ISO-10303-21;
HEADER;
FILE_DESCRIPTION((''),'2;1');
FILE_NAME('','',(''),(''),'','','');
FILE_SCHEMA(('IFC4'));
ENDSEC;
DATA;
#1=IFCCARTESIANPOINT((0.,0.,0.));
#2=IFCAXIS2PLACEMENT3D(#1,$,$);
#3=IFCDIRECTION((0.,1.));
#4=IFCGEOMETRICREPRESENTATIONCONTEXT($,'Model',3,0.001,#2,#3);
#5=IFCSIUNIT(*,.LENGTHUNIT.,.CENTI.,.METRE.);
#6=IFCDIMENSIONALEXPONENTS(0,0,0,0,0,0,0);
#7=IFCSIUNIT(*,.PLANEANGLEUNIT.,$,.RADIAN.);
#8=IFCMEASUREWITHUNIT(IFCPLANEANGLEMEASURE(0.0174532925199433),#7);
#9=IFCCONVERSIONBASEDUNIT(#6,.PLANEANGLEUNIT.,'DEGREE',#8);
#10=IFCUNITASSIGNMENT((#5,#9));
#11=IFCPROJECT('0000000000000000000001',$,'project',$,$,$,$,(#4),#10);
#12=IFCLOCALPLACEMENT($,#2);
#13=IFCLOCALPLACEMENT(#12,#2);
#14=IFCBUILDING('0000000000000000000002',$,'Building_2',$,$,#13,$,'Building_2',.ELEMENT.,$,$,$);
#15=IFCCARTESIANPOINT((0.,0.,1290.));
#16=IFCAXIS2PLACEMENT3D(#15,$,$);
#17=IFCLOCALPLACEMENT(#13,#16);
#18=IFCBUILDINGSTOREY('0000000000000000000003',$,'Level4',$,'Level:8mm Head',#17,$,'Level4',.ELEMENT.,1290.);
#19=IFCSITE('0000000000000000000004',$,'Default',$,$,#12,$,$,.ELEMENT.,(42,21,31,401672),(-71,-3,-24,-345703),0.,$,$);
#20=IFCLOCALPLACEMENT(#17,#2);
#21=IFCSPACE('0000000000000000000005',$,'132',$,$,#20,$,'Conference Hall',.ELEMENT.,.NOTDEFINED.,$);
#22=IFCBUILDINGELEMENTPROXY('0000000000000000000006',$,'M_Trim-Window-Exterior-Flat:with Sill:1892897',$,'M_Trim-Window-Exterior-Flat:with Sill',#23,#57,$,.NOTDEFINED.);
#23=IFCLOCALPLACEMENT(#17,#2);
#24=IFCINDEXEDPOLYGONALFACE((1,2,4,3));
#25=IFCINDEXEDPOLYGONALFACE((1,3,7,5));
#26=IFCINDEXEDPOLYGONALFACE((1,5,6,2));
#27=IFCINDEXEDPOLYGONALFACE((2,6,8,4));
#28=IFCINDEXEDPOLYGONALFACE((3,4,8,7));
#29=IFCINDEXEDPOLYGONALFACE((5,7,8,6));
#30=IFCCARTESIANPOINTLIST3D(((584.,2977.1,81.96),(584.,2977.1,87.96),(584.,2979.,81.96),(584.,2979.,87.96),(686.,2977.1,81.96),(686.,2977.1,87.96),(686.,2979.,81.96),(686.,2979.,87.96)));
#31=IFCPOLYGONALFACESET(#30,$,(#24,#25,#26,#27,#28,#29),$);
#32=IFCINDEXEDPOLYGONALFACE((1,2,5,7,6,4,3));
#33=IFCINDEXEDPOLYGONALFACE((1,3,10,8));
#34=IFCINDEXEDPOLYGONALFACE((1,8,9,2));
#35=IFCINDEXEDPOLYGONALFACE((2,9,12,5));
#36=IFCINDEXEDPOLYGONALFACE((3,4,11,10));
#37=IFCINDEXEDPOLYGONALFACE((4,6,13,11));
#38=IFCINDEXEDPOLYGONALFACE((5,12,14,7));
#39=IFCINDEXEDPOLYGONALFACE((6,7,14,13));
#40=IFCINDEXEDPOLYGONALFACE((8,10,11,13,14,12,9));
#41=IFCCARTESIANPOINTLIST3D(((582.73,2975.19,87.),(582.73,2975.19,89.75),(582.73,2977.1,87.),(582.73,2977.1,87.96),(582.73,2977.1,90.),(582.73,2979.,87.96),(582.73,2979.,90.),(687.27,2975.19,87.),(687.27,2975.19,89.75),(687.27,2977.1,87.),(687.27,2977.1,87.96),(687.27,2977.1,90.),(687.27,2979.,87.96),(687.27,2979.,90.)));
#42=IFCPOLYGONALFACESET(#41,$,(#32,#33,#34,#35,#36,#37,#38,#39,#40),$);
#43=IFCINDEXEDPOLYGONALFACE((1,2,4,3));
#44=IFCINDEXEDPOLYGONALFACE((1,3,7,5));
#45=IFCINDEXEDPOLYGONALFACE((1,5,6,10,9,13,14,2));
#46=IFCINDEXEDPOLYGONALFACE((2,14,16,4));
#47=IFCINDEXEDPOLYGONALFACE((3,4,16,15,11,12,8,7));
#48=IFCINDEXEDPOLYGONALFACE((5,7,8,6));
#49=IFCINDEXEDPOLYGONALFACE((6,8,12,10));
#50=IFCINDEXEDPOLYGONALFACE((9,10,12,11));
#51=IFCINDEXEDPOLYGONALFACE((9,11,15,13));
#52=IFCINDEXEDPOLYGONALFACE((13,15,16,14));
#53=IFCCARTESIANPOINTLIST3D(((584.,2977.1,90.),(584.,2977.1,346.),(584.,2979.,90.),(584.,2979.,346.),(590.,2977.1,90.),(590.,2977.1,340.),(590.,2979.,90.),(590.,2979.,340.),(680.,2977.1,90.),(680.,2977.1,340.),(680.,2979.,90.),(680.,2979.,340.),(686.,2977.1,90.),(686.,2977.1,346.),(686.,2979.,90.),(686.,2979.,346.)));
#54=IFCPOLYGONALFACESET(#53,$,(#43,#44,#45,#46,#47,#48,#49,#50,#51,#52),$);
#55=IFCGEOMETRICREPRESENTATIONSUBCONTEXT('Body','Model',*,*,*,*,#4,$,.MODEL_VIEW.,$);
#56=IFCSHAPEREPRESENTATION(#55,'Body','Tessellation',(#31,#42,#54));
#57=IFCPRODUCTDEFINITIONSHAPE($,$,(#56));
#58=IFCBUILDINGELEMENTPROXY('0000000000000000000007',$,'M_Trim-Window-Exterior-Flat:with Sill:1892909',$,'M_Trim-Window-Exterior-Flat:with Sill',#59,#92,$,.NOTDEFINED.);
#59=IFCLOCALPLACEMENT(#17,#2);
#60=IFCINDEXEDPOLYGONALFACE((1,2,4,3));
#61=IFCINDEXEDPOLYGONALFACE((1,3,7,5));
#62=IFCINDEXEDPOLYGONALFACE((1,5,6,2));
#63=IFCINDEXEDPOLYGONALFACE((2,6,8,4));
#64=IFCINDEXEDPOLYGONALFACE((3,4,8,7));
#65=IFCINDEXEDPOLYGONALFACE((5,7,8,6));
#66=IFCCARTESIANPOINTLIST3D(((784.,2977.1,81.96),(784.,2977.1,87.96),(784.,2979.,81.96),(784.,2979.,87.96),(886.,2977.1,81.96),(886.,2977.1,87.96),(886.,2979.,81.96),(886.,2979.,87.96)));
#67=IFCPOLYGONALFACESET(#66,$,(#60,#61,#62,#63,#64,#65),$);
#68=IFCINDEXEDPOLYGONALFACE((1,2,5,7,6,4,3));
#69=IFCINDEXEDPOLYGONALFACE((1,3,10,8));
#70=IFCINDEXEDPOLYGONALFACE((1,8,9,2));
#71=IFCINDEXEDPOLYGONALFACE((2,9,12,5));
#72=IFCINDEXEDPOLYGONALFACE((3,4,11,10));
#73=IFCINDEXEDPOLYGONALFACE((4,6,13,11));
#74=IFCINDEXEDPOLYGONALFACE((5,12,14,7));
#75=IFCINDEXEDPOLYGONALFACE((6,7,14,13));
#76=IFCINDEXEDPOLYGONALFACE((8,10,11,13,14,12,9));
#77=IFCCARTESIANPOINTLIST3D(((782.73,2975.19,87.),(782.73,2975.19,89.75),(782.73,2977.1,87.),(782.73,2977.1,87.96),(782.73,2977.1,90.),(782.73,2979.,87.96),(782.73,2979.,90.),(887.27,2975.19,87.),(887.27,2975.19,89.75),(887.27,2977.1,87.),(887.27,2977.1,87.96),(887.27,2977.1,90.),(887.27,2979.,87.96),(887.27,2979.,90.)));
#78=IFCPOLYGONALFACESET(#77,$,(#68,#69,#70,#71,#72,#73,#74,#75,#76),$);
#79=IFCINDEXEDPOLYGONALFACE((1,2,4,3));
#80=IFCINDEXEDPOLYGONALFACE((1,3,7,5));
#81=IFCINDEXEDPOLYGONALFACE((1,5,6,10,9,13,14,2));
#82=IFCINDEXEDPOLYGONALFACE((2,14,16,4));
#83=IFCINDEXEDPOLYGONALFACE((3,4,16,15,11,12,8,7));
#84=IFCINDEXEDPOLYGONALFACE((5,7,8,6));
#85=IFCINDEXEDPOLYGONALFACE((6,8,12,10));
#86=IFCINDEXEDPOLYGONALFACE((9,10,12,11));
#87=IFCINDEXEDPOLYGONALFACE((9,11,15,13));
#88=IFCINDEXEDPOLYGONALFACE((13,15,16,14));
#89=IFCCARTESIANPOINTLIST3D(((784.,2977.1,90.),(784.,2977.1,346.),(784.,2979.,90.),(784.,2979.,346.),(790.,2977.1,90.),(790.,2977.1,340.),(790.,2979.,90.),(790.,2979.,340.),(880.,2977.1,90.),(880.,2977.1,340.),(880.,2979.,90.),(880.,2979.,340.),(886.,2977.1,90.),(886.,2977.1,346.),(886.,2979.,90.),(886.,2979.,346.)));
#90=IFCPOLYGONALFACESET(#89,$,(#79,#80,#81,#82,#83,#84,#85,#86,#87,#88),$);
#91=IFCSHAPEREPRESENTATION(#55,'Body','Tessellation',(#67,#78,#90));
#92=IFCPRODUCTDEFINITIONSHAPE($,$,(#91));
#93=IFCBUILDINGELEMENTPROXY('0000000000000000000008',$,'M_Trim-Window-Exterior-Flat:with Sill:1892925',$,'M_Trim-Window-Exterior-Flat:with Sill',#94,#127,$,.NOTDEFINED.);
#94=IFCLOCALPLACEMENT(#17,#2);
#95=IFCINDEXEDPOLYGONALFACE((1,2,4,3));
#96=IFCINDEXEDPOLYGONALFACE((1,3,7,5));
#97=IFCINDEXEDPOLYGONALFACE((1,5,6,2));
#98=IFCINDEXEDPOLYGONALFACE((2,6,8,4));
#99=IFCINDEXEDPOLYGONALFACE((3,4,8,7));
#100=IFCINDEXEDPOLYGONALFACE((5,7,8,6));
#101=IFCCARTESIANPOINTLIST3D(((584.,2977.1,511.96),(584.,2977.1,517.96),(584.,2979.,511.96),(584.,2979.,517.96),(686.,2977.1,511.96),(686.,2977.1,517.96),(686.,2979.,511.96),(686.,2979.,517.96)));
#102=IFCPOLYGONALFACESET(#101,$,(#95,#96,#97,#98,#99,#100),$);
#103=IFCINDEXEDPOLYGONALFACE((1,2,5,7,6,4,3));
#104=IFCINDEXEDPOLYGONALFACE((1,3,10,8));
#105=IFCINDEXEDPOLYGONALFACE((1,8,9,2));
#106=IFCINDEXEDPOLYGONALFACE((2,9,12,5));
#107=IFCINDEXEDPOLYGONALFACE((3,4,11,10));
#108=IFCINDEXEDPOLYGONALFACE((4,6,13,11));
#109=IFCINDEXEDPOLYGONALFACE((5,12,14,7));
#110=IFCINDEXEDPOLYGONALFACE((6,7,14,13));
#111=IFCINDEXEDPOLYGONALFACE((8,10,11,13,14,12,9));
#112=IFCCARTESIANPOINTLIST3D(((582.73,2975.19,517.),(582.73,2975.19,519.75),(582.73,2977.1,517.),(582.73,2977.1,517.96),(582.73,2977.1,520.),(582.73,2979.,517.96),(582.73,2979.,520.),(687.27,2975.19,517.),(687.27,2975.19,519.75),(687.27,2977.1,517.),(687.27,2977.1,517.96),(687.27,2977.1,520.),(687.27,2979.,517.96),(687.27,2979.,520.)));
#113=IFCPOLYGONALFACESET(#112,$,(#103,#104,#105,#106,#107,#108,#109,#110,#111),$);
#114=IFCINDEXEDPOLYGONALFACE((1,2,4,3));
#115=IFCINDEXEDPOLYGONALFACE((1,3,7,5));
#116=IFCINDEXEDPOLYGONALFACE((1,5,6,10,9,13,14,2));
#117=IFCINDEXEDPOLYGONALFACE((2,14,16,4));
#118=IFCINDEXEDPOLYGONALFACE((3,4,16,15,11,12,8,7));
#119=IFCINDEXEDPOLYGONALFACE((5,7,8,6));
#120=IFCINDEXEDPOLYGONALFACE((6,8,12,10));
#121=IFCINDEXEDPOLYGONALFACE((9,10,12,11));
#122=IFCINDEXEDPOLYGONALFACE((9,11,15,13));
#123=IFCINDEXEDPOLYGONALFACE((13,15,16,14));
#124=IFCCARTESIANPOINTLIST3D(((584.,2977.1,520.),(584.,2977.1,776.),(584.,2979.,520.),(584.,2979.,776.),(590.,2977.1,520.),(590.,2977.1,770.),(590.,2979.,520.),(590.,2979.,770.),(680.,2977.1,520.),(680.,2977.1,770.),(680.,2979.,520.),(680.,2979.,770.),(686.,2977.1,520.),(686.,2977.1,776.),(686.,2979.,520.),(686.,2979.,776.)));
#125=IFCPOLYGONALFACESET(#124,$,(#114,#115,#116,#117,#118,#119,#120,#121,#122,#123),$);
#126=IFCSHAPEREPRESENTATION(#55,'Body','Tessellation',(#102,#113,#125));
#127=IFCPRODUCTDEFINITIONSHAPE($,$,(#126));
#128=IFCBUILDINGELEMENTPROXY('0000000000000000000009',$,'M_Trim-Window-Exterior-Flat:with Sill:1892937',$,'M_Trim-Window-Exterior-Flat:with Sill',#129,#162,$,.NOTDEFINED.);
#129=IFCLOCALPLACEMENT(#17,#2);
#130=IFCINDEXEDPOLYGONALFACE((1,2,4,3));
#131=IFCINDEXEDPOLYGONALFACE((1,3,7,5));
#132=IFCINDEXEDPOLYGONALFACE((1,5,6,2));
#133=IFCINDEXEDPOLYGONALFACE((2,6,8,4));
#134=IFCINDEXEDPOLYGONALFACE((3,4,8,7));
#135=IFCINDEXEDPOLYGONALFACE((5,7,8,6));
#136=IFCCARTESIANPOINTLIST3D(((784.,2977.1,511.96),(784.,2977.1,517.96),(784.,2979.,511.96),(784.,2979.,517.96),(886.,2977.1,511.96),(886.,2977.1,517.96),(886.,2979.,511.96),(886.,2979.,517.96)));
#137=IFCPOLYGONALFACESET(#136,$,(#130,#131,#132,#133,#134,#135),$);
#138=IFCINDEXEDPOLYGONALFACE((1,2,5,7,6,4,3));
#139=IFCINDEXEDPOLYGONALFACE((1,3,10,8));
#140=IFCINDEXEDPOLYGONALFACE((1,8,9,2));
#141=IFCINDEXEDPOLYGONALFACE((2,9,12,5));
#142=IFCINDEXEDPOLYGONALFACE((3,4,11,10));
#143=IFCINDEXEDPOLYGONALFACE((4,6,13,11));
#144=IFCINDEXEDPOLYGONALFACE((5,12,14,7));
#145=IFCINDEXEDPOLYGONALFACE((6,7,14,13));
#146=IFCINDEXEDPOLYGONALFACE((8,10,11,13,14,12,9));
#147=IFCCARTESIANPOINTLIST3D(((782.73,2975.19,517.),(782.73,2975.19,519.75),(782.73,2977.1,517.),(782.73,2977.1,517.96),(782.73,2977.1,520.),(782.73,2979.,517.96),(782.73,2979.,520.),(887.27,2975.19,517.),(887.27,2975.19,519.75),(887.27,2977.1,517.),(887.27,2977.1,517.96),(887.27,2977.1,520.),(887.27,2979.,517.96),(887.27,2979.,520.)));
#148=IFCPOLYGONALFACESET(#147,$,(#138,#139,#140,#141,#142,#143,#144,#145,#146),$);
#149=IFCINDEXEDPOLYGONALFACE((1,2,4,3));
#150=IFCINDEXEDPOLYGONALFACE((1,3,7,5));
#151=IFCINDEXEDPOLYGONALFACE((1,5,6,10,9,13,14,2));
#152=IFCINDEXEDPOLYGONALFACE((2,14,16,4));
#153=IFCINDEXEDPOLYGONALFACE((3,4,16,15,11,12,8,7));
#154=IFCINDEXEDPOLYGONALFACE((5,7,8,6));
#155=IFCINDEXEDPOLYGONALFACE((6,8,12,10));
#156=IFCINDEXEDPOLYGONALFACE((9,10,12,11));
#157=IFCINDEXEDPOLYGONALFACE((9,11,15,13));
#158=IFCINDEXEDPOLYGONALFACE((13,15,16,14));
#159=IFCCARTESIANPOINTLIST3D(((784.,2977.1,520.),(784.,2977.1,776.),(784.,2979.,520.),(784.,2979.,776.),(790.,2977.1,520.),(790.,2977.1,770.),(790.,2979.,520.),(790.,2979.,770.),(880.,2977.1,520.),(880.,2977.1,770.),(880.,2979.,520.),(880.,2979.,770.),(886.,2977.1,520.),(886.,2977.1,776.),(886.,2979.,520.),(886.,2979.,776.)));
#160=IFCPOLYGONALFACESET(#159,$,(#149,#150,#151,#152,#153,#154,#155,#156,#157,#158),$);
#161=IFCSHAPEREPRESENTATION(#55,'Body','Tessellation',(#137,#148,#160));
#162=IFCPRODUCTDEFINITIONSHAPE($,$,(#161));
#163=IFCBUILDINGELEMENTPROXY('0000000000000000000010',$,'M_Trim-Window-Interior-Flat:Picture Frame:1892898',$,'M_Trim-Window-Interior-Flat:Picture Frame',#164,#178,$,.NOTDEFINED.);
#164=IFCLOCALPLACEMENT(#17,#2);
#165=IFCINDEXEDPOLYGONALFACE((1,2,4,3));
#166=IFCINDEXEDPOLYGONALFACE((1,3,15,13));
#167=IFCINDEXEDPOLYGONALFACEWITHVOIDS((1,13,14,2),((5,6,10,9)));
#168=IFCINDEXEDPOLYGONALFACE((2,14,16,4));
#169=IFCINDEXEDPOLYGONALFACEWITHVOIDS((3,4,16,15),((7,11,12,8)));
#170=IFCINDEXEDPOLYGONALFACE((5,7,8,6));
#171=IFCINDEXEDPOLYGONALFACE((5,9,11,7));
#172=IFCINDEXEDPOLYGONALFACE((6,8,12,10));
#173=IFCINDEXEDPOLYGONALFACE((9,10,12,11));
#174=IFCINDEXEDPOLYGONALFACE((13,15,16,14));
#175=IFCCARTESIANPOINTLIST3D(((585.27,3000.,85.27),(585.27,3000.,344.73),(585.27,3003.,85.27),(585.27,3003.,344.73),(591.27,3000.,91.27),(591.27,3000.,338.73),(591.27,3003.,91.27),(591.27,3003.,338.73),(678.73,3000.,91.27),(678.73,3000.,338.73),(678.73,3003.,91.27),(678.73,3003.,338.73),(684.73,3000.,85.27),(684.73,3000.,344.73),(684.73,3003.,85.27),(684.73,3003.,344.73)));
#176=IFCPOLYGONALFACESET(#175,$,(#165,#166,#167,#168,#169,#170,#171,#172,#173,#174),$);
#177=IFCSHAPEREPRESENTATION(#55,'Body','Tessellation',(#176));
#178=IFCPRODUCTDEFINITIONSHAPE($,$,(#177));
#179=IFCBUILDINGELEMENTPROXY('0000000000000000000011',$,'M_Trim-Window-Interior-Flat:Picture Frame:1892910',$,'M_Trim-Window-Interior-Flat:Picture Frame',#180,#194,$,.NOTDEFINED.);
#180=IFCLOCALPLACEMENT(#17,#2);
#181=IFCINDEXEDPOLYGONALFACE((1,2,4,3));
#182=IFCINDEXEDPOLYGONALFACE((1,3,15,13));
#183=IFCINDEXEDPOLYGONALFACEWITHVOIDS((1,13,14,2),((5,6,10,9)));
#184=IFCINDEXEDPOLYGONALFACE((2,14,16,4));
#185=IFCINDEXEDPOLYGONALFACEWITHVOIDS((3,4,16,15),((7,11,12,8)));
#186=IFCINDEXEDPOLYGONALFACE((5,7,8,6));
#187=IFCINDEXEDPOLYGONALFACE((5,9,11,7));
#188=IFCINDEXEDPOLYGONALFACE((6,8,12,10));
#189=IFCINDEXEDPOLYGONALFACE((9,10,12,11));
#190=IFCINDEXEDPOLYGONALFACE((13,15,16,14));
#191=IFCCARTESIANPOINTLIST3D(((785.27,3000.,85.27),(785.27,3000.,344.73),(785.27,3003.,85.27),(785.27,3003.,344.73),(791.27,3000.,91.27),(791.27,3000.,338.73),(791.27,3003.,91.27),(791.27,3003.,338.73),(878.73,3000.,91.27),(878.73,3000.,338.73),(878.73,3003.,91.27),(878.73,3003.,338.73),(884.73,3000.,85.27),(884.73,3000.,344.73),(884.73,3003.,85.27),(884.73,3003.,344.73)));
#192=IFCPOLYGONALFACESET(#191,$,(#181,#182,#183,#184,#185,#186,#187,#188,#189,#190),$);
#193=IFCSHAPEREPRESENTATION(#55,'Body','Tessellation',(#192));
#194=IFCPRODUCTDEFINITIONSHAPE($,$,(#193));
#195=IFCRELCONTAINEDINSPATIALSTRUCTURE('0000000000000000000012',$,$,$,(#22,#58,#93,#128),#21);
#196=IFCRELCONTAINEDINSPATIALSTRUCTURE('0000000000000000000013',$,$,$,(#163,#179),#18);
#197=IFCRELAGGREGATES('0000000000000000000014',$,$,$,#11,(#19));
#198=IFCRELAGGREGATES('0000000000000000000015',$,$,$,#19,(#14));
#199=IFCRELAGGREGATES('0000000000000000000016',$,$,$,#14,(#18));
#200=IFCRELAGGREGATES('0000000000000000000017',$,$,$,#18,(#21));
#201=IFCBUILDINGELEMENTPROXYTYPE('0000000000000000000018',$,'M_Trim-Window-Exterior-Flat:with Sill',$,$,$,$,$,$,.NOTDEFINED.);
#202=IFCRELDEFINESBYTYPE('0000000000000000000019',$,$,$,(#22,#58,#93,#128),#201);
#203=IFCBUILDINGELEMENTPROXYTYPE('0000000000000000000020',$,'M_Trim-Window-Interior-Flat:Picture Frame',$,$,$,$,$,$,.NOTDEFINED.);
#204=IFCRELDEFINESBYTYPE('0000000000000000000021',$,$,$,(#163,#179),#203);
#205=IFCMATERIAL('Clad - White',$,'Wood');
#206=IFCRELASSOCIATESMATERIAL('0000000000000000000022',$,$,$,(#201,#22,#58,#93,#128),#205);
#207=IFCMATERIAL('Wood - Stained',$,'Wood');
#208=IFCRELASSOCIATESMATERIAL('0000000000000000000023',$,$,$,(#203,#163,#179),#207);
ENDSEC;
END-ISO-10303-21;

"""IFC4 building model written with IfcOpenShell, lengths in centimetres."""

from ifc_helpers import new_model, entity, si_unit, converted_unit, direction, frame, origin, place, context, subcontext, project, spatial, indexed_curve, outline, extrude, source, transform, mapped, material, type_object, type_shapes, element, save


model = new_model("IFC4")

# Units and contexts
model_context = context("Model", 3, precision=0.001, world=origin(), true_north=direction((0.0, 1.0)))
body_context = subcontext(model_context, "Body", "Model", "MODEL_VIEW")
ifc_project = project(units=[si_unit("LENGTHUNIT", "METRE", prefix="CENTI"), converted_unit("PLANEANGLEUNIT", "DEGREE", entity("IfcPlaneAngleMeasure", 0.0174532925199433), si_unit("PLANEANGLEUNIT", "RADIAN"), dimensions=[0, 0, 0, 0, 0, 0, 0])], contexts=[model_context])

# Site, building, storey, space
site_placement = place(None, origin())
site = spatial("IfcSite", under=ifc_project, at=site_placement, Name="Default", CompositionType="ELEMENT", RefLatitude=(42, 21, 31, 401672), RefLongitude=(-71, -3, -24, -345703), RefElevation=0.0)
building_placement = place(site_placement, origin())
building = spatial("IfcBuilding", under=site, at=building_placement, Name="Building_2", LongName="Building_2", CompositionType="ELEMENT")
storey_placement = place(building_placement, frame((0.0, 0.0, 1290.0)))
storey = spatial("IfcBuildingStorey", under=building, at=storey_placement, Name="Level4", ObjectType="Level:8mm Head", LongName="Level4", CompositionType="ELEMENT", Elevation=1290.0)
space_placement = place(storey_placement, origin())
space = spatial("IfcSpace", under=storey, at=space_placement, Name="132", LongName="Conference Hall", CompositionType="ELEMENT", PredefinedType="NOTDEFINED")

# Building element proxies
ifc_material_1 = material(Name="Clad - White", Category="Wood")
building_element_proxy_type_1 = type_object("IfcBuildingElementProxyType", Name="M_Trim-Window-Exterior-Flat:with Sill", PredefinedType="NOTDEFINED", material=ifc_material_1)
shared_shape_1 = source(origin(), body_context, "Body", "SweptSolid", [
    extrude(outline(indexed_curve([(-3.0, -51.0), (3.0, -51.0), (3.0, 51.0), (-3.0, 51.0), (-3.0, -51.0)], self_intersect=False)), frame((0.0, 255.04, 0.0), z_axis=(0.0, 0.0, 1.0), x_axis=(0.0, 1.0, 0.0)), (0.0, 0.0, 1.0), 1.91),
    extrude(outline(indexed_curve([(-1.52, -1.9), (1.23, -1.9), (1.48, 0.0), (1.48, 1.9), (-0.57, 1.9), (-0.57, 0.0), (-1.52, 0.0), (-1.52, -1.9)], self_intersect=False)), frame((-52.27, 251.48, 1.9), z_axis=(1.0, 0.0, 0.0), x_axis=(0.0, -1.0, 0.0)), (0.0, 0.0, 1.0), 104.54),
    extrude(outline(indexed_curve([(-51.0, -129.5), (51.0, -129.5), (51.0, 126.5), (45.0, 126.5), (45.0, -123.5), (-45.0, -123.5), (-45.0, 126.5), (-51.0, 126.5), (-51.0, -129.5)], self_intersect=False)), frame((0.0, 123.5, 0.0)), (0.0, 0.0, 1.0), 1.91),
])
type_shapes(building_element_proxy_type_1, [shared_shape_1])
for number, where, z_axis, x_axis, name in (
    (1, (635.0, 2979.0, 340.0), (0.0, -1.0, 0.0), (-1.0, 0.0, 0.0), "M_Trim-Window-Exterior-Flat:with Sill:1892897"),
    (2, (835.0, 2979.0, 340.0), (0.0, -1.0, 0.0), (-1.0, 0.0, 0.0), "M_Trim-Window-Exterior-Flat:with Sill:1892909"),
    (3, (635.0, 2979.0, 770.0), (0.0, -1.0, 0.0), (-1.0, 0.0, 0.0), "M_Trim-Window-Exterior-Flat:with Sill:1892925"),
    (4, (835.0, 2979.0, 770.0), (0.0, -1.0, 0.0), (-1.0, 0.0, 0.0), "M_Trim-Window-Exterior-Flat:with Sill:1892937"),
):
    element("IfcBuildingElementProxy", number, at=place(space_placement, frame(where, z_axis=z_axis, x_axis=x_axis)), inside=space, type_object=building_element_proxy_type_1, material=ifc_material_1, Name=name, ObjectType="M_Trim-Window-Exterior-Flat:with Sill", PredefinedType="NOTDEFINED", context=body_context, shape_type="MappedRepresentation", body=[
        mapped(shared_shape_1, transform((0.0, 0.0, 0.0), scale=1.0)),
    ])
ifc_material_2 = material(Name="Wood - Stained", Category="Wood")
building_element_proxy_type_2 = type_object("IfcBuildingElementProxyType", Name="M_Trim-Window-Interior-Flat:Picture Frame", PredefinedType="NOTDEFINED", material=ifc_material_2)
shared_shape_2 = source(origin(), body_context, "Body", "SweptSolid", [
    extrude(outline(indexed_curve([(-129.73, -49.73), (129.73, -49.73), (129.73, 49.73), (-129.73, 49.73), (-129.73, -49.73)], self_intersect=False), holes=[indexed_curve([(-123.73, -43.73), (-123.73, 43.73), (123.73, 43.73), (123.73, -43.73), (-123.73, -43.73)], self_intersect=False)]), frame((0.0, 125.0, 0.0), z_axis=(0.0, 0.0, 1.0), x_axis=(0.0, 1.0, 0.0)), (0.0, 0.0, 1.0), 3.0),
])
type_shapes(building_element_proxy_type_2, [shared_shape_2])
for number, where, z_axis, x_axis, name in (
    (5, (635.0, 3000.0, 340.0), (0.0, 1.0, 0.0), (1.0, 0.0, 0.0), "M_Trim-Window-Interior-Flat:Picture Frame:1892898"),
    (6, (835.0, 3000.0, 340.0), (0.0, 1.0, 0.0), (1.0, 0.0, 0.0), "M_Trim-Window-Interior-Flat:Picture Frame:1892910"),
):
    element("IfcBuildingElementProxy", number, at=place(storey_placement, frame(where, z_axis=z_axis, x_axis=x_axis)), inside=storey, type_object=building_element_proxy_type_2, material=ifc_material_2, Name=name, ObjectType="M_Trim-Window-Interior-Flat:Picture Frame", PredefinedType="NOTDEFINED", context=body_context, shape_type="MappedRepresentation", body=[
        mapped(shared_shape_2, transform((0.0, 0.0, 0.0), scale=1.0)),
    ])

save(model, "model.ifc")
